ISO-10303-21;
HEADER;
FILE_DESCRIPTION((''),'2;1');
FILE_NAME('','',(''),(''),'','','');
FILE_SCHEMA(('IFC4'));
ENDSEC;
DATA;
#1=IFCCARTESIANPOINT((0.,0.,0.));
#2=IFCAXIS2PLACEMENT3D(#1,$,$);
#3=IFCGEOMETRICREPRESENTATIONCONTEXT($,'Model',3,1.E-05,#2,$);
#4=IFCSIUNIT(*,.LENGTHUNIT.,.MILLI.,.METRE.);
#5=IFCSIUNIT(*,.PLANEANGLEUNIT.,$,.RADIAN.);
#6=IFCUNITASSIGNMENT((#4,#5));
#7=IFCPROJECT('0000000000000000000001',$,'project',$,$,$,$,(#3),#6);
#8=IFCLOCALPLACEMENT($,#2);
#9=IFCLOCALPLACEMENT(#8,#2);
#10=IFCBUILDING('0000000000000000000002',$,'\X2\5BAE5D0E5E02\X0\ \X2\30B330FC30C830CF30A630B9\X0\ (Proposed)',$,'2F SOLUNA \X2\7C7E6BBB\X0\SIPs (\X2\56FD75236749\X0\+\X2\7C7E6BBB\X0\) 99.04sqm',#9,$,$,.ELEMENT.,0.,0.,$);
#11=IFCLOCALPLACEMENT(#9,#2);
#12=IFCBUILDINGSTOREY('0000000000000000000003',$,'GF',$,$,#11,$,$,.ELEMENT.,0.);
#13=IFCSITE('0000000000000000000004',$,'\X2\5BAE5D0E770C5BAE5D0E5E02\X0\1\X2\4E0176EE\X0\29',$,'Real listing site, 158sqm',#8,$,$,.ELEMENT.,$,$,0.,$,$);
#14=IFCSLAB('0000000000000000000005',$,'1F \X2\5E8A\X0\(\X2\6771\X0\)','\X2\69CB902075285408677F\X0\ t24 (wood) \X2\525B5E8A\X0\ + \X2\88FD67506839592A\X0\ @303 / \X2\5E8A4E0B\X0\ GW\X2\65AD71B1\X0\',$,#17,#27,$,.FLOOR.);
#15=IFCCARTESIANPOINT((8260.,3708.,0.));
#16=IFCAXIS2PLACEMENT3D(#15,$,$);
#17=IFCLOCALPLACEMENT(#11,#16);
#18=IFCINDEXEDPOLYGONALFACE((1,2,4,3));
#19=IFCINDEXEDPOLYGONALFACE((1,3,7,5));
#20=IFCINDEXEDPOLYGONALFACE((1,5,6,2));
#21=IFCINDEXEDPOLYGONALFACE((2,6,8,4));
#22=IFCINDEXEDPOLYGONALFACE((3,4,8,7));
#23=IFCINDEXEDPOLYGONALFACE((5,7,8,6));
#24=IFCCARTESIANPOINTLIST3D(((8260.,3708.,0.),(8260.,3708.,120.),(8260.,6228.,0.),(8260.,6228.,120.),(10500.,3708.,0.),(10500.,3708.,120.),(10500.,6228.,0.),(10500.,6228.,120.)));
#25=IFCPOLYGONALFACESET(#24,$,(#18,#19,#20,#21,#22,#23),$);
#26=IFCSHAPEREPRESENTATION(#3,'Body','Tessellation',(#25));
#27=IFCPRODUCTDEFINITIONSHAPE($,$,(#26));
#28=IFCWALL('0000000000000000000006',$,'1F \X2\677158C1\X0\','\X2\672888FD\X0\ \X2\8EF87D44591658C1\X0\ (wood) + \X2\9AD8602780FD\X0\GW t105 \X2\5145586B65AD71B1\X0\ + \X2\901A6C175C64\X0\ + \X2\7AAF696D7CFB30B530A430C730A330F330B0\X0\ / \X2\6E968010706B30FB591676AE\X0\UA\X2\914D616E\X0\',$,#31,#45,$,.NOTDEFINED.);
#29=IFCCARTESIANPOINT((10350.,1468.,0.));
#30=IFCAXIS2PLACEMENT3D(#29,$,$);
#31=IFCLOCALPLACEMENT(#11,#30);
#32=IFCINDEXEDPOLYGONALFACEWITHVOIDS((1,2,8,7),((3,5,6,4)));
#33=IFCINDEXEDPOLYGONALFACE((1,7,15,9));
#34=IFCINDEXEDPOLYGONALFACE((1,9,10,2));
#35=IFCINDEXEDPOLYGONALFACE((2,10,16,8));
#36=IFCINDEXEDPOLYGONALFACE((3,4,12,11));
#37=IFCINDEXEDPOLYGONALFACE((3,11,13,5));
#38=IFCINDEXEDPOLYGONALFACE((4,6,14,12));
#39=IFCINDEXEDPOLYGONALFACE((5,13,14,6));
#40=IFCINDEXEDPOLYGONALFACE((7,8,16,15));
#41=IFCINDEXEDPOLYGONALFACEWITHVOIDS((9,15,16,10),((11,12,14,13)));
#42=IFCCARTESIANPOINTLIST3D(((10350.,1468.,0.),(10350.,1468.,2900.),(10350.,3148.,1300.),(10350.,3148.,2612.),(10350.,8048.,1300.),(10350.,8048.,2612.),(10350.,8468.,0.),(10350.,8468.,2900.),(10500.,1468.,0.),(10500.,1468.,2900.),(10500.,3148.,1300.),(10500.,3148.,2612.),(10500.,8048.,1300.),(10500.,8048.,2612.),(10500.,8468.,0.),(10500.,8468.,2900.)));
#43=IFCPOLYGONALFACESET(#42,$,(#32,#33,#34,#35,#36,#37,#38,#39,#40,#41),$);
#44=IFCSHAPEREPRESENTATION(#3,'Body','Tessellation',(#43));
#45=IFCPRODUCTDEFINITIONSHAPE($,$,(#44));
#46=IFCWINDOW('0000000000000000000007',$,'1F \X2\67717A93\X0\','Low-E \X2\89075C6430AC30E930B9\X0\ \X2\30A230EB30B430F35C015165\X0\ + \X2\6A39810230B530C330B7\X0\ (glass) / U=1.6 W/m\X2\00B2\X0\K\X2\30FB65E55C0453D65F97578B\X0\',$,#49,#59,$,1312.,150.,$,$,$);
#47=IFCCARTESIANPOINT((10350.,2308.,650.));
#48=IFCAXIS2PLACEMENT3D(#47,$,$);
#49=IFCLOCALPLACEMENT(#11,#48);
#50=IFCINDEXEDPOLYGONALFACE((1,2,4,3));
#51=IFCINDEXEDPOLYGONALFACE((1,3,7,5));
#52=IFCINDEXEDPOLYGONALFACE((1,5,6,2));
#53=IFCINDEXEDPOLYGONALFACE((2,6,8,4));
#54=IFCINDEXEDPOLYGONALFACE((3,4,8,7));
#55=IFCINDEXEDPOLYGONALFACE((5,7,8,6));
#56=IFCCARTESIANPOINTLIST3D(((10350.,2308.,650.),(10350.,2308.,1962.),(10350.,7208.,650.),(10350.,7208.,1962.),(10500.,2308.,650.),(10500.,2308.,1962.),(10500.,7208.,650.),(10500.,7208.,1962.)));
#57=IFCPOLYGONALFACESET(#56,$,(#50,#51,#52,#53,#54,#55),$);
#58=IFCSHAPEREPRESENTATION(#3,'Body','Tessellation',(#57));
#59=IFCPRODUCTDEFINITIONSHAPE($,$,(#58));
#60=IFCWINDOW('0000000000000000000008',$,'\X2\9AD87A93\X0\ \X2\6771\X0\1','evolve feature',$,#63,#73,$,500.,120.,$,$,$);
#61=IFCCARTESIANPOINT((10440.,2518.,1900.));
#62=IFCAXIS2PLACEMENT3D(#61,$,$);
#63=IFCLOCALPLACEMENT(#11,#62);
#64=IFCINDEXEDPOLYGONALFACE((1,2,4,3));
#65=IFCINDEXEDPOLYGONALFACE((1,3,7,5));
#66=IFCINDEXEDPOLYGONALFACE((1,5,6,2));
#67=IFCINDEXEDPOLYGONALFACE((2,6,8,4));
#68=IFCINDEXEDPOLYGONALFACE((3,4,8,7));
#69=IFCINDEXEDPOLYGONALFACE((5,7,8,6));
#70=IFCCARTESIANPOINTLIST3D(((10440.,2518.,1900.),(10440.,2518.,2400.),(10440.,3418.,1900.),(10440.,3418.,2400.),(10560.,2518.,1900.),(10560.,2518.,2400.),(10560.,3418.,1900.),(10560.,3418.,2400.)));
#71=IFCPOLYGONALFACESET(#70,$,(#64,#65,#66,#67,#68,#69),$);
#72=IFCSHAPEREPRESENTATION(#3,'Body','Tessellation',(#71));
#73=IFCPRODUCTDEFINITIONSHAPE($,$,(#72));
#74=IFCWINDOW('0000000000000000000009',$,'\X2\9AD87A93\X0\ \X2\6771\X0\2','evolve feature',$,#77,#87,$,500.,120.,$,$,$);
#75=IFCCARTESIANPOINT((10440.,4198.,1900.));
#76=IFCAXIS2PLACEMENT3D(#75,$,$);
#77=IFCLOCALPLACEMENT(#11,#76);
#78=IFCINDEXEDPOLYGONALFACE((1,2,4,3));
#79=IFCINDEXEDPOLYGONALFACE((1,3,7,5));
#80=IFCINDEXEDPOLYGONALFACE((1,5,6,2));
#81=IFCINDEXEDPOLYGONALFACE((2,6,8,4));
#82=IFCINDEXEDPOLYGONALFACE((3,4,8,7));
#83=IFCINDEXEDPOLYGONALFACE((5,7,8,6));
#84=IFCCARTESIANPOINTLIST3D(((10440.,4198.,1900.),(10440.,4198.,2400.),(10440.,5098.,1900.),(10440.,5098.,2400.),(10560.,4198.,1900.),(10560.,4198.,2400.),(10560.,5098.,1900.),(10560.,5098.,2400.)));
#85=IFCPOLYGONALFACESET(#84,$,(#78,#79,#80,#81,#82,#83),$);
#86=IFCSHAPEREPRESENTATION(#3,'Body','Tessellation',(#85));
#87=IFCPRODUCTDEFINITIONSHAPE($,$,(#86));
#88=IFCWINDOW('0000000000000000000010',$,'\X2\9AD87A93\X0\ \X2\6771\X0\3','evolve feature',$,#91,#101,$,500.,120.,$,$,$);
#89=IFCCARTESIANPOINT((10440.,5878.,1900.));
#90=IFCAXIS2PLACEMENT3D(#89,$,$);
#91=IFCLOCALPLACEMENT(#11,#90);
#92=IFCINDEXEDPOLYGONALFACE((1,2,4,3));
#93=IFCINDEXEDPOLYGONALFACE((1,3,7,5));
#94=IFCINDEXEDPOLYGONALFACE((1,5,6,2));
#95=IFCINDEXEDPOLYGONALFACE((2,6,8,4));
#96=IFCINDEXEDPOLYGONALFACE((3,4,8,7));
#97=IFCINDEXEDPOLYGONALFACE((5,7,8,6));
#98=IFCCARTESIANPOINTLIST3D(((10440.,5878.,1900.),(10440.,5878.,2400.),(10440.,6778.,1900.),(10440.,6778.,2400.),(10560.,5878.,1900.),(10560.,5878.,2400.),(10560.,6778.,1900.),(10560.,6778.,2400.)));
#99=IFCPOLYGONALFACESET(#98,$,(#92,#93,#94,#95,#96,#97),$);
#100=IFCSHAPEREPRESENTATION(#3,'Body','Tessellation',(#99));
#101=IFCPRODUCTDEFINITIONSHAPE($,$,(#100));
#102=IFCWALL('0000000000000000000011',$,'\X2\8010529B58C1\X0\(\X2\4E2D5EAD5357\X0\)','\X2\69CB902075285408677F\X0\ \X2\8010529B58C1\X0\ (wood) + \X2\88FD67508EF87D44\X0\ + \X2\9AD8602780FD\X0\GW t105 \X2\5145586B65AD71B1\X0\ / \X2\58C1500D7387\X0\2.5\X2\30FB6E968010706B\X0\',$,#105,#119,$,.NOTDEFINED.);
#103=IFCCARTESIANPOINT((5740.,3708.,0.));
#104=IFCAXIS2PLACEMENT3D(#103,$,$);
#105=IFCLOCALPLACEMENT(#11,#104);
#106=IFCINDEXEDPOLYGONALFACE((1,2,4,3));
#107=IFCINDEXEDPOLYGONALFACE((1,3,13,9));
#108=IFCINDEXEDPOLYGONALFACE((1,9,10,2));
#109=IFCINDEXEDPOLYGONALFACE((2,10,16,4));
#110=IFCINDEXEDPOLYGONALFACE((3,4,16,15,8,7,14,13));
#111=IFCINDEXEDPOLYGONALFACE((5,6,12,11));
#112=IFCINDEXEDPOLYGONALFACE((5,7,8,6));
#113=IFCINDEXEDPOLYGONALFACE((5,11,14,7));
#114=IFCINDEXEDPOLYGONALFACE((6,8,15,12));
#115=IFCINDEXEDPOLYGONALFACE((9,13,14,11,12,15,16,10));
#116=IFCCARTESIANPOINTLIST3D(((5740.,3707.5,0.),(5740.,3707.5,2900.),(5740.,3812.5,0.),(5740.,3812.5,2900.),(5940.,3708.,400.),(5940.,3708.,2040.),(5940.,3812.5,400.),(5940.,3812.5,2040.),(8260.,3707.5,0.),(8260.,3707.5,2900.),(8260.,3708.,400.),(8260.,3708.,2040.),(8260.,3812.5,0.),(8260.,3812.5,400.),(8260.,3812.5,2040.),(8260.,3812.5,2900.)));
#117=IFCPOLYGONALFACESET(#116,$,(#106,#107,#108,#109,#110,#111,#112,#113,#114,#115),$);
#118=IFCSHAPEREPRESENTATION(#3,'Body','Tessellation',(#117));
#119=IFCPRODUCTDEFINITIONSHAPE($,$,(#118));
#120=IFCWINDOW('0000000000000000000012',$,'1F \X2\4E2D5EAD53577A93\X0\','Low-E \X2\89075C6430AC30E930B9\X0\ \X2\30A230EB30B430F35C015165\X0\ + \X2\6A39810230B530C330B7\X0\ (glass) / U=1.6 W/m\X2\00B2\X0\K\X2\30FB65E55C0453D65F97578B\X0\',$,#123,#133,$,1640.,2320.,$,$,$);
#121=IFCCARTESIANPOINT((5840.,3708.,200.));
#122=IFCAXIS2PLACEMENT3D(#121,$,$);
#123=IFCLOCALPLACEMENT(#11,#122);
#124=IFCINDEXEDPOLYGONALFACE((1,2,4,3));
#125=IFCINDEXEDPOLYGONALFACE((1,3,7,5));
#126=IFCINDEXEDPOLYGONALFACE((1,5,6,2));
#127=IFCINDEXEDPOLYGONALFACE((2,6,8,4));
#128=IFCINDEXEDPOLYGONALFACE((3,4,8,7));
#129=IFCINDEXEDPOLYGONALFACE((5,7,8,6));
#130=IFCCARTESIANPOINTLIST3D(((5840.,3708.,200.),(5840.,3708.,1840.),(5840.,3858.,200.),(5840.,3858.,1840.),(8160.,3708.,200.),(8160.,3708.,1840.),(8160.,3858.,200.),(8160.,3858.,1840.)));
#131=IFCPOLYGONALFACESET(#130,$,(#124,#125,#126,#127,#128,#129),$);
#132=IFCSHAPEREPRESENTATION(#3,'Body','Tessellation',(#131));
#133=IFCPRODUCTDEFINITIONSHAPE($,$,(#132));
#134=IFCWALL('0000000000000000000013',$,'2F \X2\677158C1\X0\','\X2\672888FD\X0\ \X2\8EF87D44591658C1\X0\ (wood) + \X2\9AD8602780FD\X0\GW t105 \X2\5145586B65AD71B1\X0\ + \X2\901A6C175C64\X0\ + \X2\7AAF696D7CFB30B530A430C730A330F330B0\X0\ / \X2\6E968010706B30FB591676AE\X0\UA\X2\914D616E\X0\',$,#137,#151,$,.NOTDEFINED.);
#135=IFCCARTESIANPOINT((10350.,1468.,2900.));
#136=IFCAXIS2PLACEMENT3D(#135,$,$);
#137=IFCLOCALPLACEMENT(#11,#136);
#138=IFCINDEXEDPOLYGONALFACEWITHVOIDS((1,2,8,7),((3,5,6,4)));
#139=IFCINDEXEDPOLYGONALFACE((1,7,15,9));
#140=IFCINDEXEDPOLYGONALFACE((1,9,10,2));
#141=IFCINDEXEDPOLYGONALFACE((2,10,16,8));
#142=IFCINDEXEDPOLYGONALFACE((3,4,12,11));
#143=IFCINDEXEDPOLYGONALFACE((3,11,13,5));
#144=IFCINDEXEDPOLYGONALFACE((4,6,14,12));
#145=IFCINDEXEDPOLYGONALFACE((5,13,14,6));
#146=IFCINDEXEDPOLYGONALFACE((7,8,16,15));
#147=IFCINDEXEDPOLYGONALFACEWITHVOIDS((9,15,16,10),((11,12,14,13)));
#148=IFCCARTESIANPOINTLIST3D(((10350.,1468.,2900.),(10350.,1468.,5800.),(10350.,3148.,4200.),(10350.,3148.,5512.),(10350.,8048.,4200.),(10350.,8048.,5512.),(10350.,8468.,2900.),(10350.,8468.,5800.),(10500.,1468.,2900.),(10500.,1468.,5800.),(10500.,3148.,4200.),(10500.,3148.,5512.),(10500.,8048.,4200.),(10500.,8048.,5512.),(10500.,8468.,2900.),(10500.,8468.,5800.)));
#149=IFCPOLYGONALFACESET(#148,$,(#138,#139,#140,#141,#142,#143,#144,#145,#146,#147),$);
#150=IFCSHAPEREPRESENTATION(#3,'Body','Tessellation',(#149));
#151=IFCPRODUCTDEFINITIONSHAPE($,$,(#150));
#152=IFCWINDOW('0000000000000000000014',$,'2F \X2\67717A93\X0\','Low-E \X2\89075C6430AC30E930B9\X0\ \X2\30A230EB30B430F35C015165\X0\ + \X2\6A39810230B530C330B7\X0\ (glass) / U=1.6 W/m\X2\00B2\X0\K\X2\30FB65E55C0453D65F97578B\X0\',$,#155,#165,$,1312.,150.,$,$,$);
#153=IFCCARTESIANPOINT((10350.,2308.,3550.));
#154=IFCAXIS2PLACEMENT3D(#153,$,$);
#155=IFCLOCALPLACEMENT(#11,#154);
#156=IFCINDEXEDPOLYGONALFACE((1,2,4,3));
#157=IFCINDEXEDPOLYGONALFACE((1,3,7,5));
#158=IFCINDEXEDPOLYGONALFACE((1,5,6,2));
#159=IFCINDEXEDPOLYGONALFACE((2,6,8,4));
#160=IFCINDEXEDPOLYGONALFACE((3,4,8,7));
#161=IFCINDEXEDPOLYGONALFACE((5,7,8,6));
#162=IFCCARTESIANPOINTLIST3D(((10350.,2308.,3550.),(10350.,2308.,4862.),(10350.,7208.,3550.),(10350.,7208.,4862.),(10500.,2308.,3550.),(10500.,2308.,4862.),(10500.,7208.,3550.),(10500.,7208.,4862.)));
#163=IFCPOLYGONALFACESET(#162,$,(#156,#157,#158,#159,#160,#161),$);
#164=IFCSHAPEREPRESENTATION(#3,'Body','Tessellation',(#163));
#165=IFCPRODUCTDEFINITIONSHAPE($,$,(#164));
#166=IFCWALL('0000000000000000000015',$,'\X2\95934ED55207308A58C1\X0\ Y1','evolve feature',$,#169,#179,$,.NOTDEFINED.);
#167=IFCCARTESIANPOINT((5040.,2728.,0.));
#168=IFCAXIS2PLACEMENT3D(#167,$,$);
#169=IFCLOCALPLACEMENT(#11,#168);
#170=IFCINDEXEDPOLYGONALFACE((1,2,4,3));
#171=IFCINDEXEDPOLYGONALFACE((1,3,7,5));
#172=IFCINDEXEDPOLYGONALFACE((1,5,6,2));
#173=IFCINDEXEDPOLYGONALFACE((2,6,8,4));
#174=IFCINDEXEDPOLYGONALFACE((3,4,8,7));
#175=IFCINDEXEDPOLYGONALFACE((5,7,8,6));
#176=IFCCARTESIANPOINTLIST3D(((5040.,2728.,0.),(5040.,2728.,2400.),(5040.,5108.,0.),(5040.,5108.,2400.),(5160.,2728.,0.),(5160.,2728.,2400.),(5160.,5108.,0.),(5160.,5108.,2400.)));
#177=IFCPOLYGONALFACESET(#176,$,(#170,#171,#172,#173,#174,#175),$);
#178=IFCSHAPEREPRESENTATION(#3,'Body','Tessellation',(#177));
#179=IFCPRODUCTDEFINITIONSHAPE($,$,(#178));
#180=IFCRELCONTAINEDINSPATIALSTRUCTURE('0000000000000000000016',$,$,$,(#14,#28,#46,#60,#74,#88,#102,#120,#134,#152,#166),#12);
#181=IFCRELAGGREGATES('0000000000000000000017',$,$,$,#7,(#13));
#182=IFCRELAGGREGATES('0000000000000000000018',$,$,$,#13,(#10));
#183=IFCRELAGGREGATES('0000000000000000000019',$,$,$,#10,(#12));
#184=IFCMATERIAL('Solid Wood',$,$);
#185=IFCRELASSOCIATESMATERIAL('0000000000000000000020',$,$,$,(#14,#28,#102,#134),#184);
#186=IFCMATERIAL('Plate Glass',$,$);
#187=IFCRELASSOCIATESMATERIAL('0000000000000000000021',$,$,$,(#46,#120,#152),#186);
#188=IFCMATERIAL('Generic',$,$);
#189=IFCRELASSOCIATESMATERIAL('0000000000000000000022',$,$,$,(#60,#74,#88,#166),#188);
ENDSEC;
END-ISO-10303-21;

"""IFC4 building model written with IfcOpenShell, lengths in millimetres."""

from ifc_helpers import new_model, si_unit, frame, frame_2d, origin, place, context, project, spatial, rectangle, extrude, material, element, fill, save


model = new_model("IFC4")

# Units and contexts
model_context = context("Model", 3, precision=1e-05, world=origin())
ifc_project = project(units=[si_unit("LENGTHUNIT", "METRE", prefix="MILLI"), si_unit("PLANEANGLEUNIT", "RADIAN")], contexts=[model_context])

# Site, building, storey
site_placement = place(None, origin())
site = spatial("IfcSite", under=ifc_project, at=site_placement, Name="宮崎県宮崎市1丁目29", ObjectType="Real listing site, 158sqm", CompositionType="ELEMENT", RefElevation=0.0)
building_placement = place(site_placement, origin())
building = spatial("IfcBuilding", under=site, at=building_placement, Name="宮崎市 コートハウス (Proposed)", ObjectType="2F SOLUNA 籾殻SIPs (国産杉+籾殻) 99.04sqm", CompositionType="ELEMENT", ElevationOfRefHeight=0.0, ElevationOfTerrain=0.0)
storey_placement = place(building_placement, origin())
storey = spatial("IfcBuildingStorey", under=building, at=storey_placement, Name="GF", CompositionType="ELEMENT", Elevation=0.0)

# Slab
ifc_material_1 = material(Name="Solid Wood")
slab_placement = place(storey_placement, frame((8260.0, 3708.0, 0.0)))
element("IfcSlab", 1, at=slab_placement, inside=storey, material=ifc_material_1, Name="1F 床(東)", Description="構造用合板 t24 (wood) 剛床 + 製材根太 @303 / 床下 GW断熱", PredefinedType="FLOOR", context=model_context, shape_type="SweptSolid", body=[
    extrude(rectangle(XDim=2240.0, YDim=2520.0, at=frame_2d((1120.0, 1260.0))), frame((8260.0, 3708.0, 0.0)), (0.0, 0.0, 1.0), 120.0),
])

# Wall, openings, windows
wall_1_placement = place(storey_placement, frame((10350.0, 1468.0, 0.0)))
wall_1 = element("IfcWall", 2, at=wall_1_placement, inside=storey, material=ifc_material_1, Name="1F 東壁", Description="木製 軸組外壁 (wood) + 高性能GW t105 充填断熱 + 通気層 + 窯業系サイディング / 準耐火・外皮UA配慮", PredefinedType="NOTDEFINED", context=model_context, shape_type="SweptSolid", body=[
    extrude(rectangle(XDim=150.0, YDim=7000.0, at=frame_2d((75.0, 3500.0))), frame((10350.0, 1468.0, 0.0)), (0.0, 0.0, 1.0), 2900.0),
])
opening_1_placement = place(storey_placement, frame((10350.0, 2308.0, 650.0)))
opening_1 = element("IfcOpeningElement", 3, at=opening_1_placement, cuts=wall_1, PredefinedType="NOTDEFINED", context=model_context, shape_type="SweptSolid", body=[
    extrude(rectangle(XDim=150.0, YDim=4900.0, at=frame_2d((75.0, 2450.0))), frame((10350.0, 2308.0, 650.0)), (0.0, 0.0, 1.0), 1312.0),
])
opening_2_placement = place(storey_placement, frame((10440.0, 2518.0, 1900.0)))
opening_2 = element("IfcOpeningElement", 4, at=opening_2_placement, cuts=wall_1, PredefinedType="NOTDEFINED", context=model_context, shape_type="SweptSolid", body=[
    extrude(rectangle(XDim=120.0, YDim=900.0, at=frame_2d((60.0, 450.0))), frame((10440.0, 2518.0, 1900.0)), (0.0, 0.0, 1.0), 500.0),
])
opening_3_placement = place(storey_placement, frame((10440.0, 4198.0, 1900.0)))
opening_3 = element("IfcOpeningElement", 5, at=opening_3_placement, cuts=wall_1, PredefinedType="NOTDEFINED", context=model_context, shape_type="SweptSolid", body=[
    extrude(rectangle(XDim=120.0, YDim=900.0, at=frame_2d((60.0, 450.0))), frame((10440.0, 4198.0, 1900.0)), (0.0, 0.0, 1.0), 500.0),
])
opening_4_placement = place(storey_placement, frame((10440.0, 5878.0, 1900.0)))
opening_4 = element("IfcOpeningElement", 6, at=opening_4_placement, cuts=wall_1, PredefinedType="NOTDEFINED", context=model_context, shape_type="SweptSolid", body=[
    extrude(rectangle(XDim=120.0, YDim=900.0, at=frame_2d((60.0, 450.0))), frame((10440.0, 5878.0, 1900.0)), (0.0, 0.0, 1.0), 500.0),
])
ifc_material_2 = material(Name="Plate Glass")
window_1_placement = place(storey_placement, frame((10350.0, 2308.0, 650.0)))
window_1 = element("IfcWindow", 7, at=window_1_placement, inside=storey, material=ifc_material_2, Name="1F 東窓", Description="Low-E 複層ガラス アルゴン封入 + 樹脂サッシ (glass) / U=1.6 W/m²K・日射取得型", OverallHeight=1312.0, OverallWidth=150.0, context=model_context, shape_type="SweptSolid", body=[
    extrude(rectangle(XDim=150.0, YDim=4900.0, at=frame_2d((75.0, 2450.0))), frame((10350.0, 2308.0, 650.0)), (0.0, 0.0, 1.0), 1312.0),
])
fill(opening_1, window_1)
ifc_material_3 = material(Name="Generic")
window_2_placement = place(storey_placement, frame((10440.0, 2518.0, 1900.0)))
window_2 = element("IfcWindow", 8, at=window_2_placement, inside=storey, material=ifc_material_3, Name="高窓 東1", Description="evolve feature", OverallHeight=500.0, OverallWidth=120.0, context=model_context, shape_type="SweptSolid", body=[
    extrude(rectangle(XDim=120.0, YDim=900.0, at=frame_2d((60.0, 450.0))), frame((10440.0, 2518.0, 1900.0)), (0.0, 0.0, 1.0), 500.0),
])
fill(opening_2, window_2)
window_3_placement = place(storey_placement, frame((10440.0, 4198.0, 1900.0)))
window_3 = element("IfcWindow", 9, at=window_3_placement, inside=storey, material=ifc_material_3, Name="高窓 東2", Description="evolve feature", OverallHeight=500.0, OverallWidth=120.0, context=model_context, shape_type="SweptSolid", body=[
    extrude(rectangle(XDim=120.0, YDim=900.0, at=frame_2d((60.0, 450.0))), frame((10440.0, 4198.0, 1900.0)), (0.0, 0.0, 1.0), 500.0),
])
fill(opening_3, window_3)
window_4_placement = place(storey_placement, frame((10440.0, 5878.0, 1900.0)))
window_4 = element("IfcWindow", 10, at=window_4_placement, inside=storey, material=ifc_material_3, Name="高窓 東3", Description="evolve feature", OverallHeight=500.0, OverallWidth=120.0, context=model_context, shape_type="SweptSolid", body=[
    extrude(rectangle(XDim=120.0, YDim=900.0, at=frame_2d((60.0, 450.0))), frame((10440.0, 5878.0, 1900.0)), (0.0, 0.0, 1.0), 500.0),
])
fill(opening_4, window_4)

# Wall, opening, window
wall_2_placement = place(storey_placement, frame((5740.0, 3708.0, 0.0)))
wall_2 = element("IfcWall", 11, at=wall_2_placement, inside=storey, material=ifc_material_1, Name="耐力壁(中庭南)", Description="構造用合板 耐力壁 (wood) + 製材軸組 + 高性能GW t105 充填断熱 / 壁倍率2.5・準耐火", PredefinedType="NOTDEFINED", context=model_context, shape_type="SweptSolid", body=[
    extrude(rectangle(XDim=2520.0, YDim=105.0, at=frame_2d((1260.0, 52.0))), frame((5740.0, 3708.0, 0.0)), (0.0, 0.0, 1.0), 2900.0),
])
opening_5_placement = place(storey_placement, frame((5840.0, 3708.0, 200.0)))
opening_5 = element("IfcOpeningElement", 12, at=opening_5_placement, cuts=wall_2, PredefinedType="NOTDEFINED", context=model_context, shape_type="SweptSolid", body=[
    extrude(rectangle(XDim=2320.0, YDim=150.0, at=frame_2d((1160.0, 75.0))), frame((5840.0, 3708.0, 200.0)), (0.0, 0.0, 1.0), 1640.0),
])
window_5_placement = place(storey_placement, frame((5840.0, 3708.0, 200.0)))
window_5 = element("IfcWindow", 13, at=window_5_placement, inside=storey, material=ifc_material_2, Name="1F 中庭南窓", Description="Low-E 複層ガラス アルゴン封入 + 樹脂サッシ (glass) / U=1.6 W/m²K・日射取得型", OverallHeight=1640.0, OverallWidth=2320.0, context=model_context, shape_type="SweptSolid", body=[
    extrude(rectangle(XDim=2320.0, YDim=150.0, at=frame_2d((1160.0, 75.0))), frame((5840.0, 3708.0, 200.0)), (0.0, 0.0, 1.0), 1640.0),
])
fill(opening_5, window_5)

# Wall, opening, window
wall_3_placement = place(storey_placement, frame((10350.0, 1468.0, 2900.0)))
wall_3 = element("IfcWall", 14, at=wall_3_placement, inside=storey, material=ifc_material_1, Name="2F 東壁", Description="木製 軸組外壁 (wood) + 高性能GW t105 充填断熱 + 通気層 + 窯業系サイディング / 準耐火・外皮UA配慮", PredefinedType="NOTDEFINED", context=model_context, shape_type="SweptSolid", body=[
    extrude(rectangle(XDim=150.0, YDim=7000.0, at=frame_2d((75.0, 3500.0))), frame((10350.0, 1468.0, 2900.0)), (0.0, 0.0, 1.0), 2900.0),
])
opening_6_placement = place(storey_placement, frame((10350.0, 2308.0, 3550.0)))
opening_6 = element("IfcOpeningElement", 15, at=opening_6_placement, cuts=wall_3, PredefinedType="NOTDEFINED", context=model_context, shape_type="SweptSolid", body=[
    extrude(rectangle(XDim=150.0, YDim=4900.0, at=frame_2d((75.0, 2450.0))), frame((10350.0, 2308.0, 3550.0)), (0.0, 0.0, 1.0), 1312.0),
])
window_6_placement = place(storey_placement, frame((10350.0, 2308.0, 3550.0)))
window_6 = element("IfcWindow", 16, at=window_6_placement, inside=storey, material=ifc_material_2, Name="2F 東窓", Description="Low-E 複層ガラス アルゴン封入 + 樹脂サッシ (glass) / U=1.6 W/m²K・日射取得型", OverallHeight=1312.0, OverallWidth=150.0, context=model_context, shape_type="SweptSolid", body=[
    extrude(rectangle(XDim=150.0, YDim=4900.0, at=frame_2d((75.0, 2450.0))), frame((10350.0, 2308.0, 3550.0)), (0.0, 0.0, 1.0), 1312.0),
])
fill(opening_6, window_6)

# Wall
wall_4_placement = place(storey_placement, frame((5040.0, 2728.0, 0.0)))
element("IfcWall", 17, at=wall_4_placement, inside=storey, material=ifc_material_3, Name="間仕切り壁 Y1", Description="evolve feature", PredefinedType="NOTDEFINED", context=model_context, shape_type="SweptSolid", body=[
    extrude(rectangle(XDim=120.0, YDim=2380.0, at=frame_2d((60.0, 1190.0))), frame((5040.0, 2728.0, 0.0)), (0.0, 0.0, 1.0), 2400.0),
])

save(model, "model.ifc")
